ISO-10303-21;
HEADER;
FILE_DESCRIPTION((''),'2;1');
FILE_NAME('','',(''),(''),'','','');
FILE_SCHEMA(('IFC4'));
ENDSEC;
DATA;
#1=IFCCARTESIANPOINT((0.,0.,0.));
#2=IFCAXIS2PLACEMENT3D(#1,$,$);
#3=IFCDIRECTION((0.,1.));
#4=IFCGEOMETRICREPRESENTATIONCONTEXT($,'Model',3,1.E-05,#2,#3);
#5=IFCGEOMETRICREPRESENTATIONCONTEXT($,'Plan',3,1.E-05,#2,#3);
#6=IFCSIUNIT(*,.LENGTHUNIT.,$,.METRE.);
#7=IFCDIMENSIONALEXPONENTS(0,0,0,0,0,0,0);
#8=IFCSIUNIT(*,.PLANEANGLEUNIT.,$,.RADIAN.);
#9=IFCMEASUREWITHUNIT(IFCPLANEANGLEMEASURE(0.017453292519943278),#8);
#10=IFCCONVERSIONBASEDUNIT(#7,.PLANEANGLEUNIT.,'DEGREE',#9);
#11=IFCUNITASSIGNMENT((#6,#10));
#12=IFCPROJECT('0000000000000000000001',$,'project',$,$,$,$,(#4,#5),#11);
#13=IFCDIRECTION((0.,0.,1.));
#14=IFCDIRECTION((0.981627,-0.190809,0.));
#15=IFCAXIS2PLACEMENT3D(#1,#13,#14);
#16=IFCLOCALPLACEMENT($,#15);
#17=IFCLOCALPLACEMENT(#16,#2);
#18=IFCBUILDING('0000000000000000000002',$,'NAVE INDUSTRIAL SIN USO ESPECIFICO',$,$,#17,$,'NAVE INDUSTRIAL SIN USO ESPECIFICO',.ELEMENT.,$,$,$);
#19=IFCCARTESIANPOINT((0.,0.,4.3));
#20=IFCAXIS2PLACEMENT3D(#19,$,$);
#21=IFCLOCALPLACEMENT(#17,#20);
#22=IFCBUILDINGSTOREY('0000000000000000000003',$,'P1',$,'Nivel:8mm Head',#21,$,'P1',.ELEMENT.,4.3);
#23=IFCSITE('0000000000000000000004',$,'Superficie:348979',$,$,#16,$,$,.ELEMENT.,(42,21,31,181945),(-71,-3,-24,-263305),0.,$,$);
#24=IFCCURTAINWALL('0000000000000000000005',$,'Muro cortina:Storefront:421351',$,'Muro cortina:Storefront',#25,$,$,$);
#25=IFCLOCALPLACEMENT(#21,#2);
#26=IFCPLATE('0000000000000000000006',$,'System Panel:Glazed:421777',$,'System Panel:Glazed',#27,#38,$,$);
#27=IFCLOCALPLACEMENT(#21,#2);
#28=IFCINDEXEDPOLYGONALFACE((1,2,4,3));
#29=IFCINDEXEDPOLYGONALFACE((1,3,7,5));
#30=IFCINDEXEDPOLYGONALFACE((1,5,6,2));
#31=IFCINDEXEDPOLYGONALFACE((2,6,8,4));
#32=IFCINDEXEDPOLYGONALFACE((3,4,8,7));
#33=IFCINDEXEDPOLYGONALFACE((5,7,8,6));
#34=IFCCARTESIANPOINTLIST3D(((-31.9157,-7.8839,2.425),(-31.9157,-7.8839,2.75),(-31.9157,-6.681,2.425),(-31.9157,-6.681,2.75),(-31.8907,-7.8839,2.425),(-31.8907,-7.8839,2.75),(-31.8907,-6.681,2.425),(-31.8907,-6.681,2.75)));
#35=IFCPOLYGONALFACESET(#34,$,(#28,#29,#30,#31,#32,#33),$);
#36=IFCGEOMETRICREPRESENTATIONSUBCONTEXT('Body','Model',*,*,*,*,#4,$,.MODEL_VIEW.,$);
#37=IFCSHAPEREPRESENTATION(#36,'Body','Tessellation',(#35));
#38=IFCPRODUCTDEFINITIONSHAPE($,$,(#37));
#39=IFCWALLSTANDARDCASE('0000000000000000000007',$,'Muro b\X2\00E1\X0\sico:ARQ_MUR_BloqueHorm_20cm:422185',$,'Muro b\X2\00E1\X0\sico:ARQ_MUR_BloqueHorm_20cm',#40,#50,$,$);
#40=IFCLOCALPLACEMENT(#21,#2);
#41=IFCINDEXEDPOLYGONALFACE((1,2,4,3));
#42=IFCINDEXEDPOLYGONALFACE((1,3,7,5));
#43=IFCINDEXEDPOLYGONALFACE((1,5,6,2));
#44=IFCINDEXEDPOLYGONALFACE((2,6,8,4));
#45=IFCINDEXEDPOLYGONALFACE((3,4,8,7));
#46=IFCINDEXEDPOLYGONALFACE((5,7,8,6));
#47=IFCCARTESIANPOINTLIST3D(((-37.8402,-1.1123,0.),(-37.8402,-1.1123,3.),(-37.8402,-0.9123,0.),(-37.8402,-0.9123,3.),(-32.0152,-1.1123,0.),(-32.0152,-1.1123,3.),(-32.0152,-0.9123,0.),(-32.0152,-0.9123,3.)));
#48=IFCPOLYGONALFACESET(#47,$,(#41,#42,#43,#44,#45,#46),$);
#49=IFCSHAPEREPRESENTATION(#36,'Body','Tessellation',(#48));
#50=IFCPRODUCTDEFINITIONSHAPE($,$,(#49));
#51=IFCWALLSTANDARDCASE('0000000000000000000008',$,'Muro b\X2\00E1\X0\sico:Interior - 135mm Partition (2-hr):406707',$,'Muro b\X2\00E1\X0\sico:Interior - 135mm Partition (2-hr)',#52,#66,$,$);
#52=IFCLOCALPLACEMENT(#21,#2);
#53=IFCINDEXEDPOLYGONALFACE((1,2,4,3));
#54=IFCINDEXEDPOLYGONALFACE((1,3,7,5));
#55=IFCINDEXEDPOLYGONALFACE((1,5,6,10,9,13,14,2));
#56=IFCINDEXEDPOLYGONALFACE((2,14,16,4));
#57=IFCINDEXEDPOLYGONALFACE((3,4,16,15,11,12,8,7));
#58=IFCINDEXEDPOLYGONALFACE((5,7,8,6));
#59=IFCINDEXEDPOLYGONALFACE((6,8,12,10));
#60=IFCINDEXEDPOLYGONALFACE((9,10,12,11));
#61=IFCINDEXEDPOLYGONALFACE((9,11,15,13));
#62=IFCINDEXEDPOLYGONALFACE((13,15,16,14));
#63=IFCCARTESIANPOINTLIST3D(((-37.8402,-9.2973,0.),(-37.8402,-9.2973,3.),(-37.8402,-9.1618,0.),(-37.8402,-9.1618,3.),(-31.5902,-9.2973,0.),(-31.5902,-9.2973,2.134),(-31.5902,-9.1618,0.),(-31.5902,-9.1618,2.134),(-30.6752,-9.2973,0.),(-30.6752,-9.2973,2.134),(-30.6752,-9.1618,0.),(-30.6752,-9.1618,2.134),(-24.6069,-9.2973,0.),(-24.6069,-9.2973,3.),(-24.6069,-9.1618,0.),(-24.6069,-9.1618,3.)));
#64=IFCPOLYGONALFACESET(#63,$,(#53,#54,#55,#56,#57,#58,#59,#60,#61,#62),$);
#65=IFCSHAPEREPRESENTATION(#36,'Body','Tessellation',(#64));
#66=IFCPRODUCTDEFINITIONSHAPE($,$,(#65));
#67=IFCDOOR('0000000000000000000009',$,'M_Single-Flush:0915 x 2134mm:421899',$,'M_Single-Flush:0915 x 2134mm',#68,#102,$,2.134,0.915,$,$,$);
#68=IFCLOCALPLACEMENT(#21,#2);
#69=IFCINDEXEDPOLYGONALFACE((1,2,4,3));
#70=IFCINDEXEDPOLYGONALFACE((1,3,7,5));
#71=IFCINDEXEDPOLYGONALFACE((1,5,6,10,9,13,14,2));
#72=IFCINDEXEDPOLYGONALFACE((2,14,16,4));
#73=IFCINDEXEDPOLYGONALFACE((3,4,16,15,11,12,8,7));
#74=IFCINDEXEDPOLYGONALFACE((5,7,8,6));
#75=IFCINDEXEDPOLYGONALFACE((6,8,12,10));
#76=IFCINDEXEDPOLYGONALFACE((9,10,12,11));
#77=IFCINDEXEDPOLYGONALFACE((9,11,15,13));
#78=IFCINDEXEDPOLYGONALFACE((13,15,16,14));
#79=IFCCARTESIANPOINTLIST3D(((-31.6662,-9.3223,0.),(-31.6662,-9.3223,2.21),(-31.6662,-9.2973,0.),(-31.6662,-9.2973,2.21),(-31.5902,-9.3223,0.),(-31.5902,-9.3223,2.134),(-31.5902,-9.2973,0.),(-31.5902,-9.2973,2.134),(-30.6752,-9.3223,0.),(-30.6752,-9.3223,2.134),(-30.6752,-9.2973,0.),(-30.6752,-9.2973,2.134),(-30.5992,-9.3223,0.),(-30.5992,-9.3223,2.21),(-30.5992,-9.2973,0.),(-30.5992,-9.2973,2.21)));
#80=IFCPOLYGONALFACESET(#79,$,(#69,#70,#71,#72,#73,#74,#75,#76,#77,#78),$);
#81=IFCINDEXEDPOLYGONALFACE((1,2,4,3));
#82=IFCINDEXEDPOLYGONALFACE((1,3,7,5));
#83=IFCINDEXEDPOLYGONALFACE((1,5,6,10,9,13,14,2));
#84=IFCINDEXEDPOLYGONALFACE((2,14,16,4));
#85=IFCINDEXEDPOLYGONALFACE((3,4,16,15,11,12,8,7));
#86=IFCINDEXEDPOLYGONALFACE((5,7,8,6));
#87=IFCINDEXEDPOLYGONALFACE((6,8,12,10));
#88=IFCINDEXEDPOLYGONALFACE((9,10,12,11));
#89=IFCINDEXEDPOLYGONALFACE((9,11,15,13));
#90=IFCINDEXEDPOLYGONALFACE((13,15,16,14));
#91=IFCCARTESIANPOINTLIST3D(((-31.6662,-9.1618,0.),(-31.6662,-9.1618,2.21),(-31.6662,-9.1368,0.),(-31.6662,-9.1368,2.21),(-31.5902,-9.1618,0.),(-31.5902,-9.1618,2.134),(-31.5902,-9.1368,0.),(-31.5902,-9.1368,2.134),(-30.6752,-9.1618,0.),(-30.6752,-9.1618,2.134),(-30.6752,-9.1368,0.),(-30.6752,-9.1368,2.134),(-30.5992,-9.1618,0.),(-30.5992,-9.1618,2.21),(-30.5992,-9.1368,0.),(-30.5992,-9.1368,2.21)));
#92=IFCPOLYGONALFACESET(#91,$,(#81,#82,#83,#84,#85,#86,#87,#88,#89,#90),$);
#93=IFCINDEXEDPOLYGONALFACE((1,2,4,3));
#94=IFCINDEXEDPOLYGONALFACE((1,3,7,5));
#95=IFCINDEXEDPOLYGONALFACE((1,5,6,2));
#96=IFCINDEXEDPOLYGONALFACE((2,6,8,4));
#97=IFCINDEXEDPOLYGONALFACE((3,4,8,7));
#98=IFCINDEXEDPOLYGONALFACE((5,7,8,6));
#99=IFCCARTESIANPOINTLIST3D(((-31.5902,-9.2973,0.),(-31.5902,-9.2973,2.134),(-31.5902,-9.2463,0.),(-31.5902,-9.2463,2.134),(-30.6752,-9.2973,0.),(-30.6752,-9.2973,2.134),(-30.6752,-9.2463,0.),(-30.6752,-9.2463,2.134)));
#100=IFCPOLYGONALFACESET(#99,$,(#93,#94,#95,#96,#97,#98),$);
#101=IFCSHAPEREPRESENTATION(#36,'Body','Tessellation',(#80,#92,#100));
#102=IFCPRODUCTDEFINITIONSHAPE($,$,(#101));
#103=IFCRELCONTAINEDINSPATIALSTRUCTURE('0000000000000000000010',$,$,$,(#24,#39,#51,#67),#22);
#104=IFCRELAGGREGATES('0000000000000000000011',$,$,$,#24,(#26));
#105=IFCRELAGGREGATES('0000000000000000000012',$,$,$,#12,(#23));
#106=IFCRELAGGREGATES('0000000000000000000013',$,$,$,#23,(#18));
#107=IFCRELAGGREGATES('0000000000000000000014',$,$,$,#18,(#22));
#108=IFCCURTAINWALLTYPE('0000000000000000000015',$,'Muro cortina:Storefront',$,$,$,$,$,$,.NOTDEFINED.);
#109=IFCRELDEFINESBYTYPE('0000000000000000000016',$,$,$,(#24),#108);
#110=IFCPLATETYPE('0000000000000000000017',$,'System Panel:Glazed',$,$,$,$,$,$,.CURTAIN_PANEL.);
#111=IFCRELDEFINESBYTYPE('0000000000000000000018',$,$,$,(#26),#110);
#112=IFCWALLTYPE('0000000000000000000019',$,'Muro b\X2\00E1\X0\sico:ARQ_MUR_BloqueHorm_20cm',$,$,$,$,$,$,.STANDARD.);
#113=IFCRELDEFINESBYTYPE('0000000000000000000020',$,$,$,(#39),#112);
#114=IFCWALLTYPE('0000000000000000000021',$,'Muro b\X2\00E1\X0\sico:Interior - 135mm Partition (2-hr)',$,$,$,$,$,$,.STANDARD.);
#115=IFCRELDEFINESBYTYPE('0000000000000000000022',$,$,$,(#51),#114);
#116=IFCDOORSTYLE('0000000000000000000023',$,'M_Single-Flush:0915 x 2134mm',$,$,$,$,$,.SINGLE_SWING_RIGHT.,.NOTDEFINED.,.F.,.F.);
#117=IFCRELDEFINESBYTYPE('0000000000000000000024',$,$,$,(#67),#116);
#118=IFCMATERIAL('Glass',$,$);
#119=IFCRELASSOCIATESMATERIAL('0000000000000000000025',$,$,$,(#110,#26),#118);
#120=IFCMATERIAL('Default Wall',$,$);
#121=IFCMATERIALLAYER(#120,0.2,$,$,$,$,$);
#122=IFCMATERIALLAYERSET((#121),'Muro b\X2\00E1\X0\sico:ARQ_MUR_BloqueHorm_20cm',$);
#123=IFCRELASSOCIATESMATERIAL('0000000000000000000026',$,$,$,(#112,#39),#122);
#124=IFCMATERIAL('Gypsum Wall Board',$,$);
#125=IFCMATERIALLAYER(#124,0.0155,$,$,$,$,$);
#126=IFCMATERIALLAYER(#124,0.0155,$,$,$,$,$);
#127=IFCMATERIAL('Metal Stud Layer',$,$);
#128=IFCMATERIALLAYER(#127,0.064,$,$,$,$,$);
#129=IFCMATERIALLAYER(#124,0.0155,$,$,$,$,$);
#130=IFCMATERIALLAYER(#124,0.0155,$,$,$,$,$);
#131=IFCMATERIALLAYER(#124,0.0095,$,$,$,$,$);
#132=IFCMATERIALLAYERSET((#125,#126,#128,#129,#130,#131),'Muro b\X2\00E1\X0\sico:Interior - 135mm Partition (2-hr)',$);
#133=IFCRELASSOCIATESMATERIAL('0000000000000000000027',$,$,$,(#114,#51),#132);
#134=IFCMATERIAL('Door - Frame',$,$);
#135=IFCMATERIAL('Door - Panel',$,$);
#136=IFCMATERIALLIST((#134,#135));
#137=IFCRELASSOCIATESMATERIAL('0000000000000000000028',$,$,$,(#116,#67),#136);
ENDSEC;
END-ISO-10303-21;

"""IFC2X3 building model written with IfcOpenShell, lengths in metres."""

from ifc_helpers import new_model, entity, si_unit, converted_unit, direction, frame, frame_2d, origin, origin_2d_with_axis, place, context, subcontext, project, spatial, polyline, rectangle, outline, extrude, source, transform, mapped, material, material_list, layer, layer_set, layer_usage, type_object, type_shapes, element, fill, aggregate, save


model = new_model("IFC2X3")

# Units and contexts
model_context = context("Model", 3, precision=1e-05, world=origin(), true_north=direction((0.0, 1.0)))
plan_context = context("Plan", 3, precision=1e-05, world=origin(), true_north=direction((0.0, 1.0)))
body_context = subcontext(model_context, "Body", "Model", "MODEL_VIEW")
ifc_project = project(units=[si_unit("LENGTHUNIT", "METRE"), converted_unit("PLANEANGLEUNIT", "DEGREE", entity("IfcPlaneAngleMeasure", 0.017453292519943278), si_unit("PLANEANGLEUNIT", "RADIAN"), dimensions=[0, 0, 0, 0, 0, 0, 0])], contexts=[model_context, plan_context])

# Site, building, storey
site_placement = place(None, frame((0.0, 0.0, 0.0), z_axis=(0.0, 0.0, 1.0), x_axis=(0.981627, -0.190809, 0.0)))
site = spatial("IfcSite", under=ifc_project, at=site_placement, Name="Superficie:348979", CompositionType="ELEMENT", RefLatitude=(42, 21, 31, 181945), RefLongitude=(-71, -3, -24, -263305), RefElevation=0.0)
building_placement = place(site_placement, origin())
building = spatial("IfcBuilding", under=site, at=building_placement, Name="NAVE INDUSTRIAL SIN USO ESPECIFICO", LongName="NAVE INDUSTRIAL SIN USO ESPECIFICO", CompositionType="ELEMENT")
storey_placement = place(building_placement, frame((0.0, 0.0, 4.3)))
storey = spatial("IfcBuildingStorey", under=building, at=storey_placement, Name="P1", ObjectType="Nivel:8mm Head", LongName="P1", CompositionType="ELEMENT", Elevation=4.3)

# Curtain wall, plate
curtain_wall_type = type_object("IfcCurtainWallType", Name="Muro cortina:Storefront", PredefinedType="NOTDEFINED")
curtain_wall_placement = place(storey_placement, frame((0.0, 0.0, -4.3)))
curtain_wall = element("IfcCurtainWall", 1, at=curtain_wall_placement, inside=storey, type_object=curtain_wall_type, Name="Muro cortina:Storefront:421351", ObjectType="Muro cortina:Storefront")
ifc_material_1 = material(Name="Glass")
ifc_material_2 = material(Name="Gypsum Wall Board")
ifc_material_3 = material(Name="Door - Frame")
ifc_material_4 = material(Name="Door - Panel")
ifc_material_list = material_list([ifc_material_3, ifc_material_4])
plate_type_1 = type_object("IfcPlateType", Name="System Panel:Glazed", PredefinedType="CURTAIN_PANEL", material=ifc_material_1)
shared_shape_1 = source(origin(), body_context, "Body", "SweptSolid", [
    extrude(rectangle(XDim=0.025, YDim=1.2029, at=origin_2d_with_axis()), frame((0.6014, 0.0125, 0.0), z_axis=(0.0, 0.0, 1.0), x_axis=(0.0, 1.0, 0.0)), (0.0, 0.0, 1.0), 0.325),
])
type_shapes(plate_type_1, [shared_shape_1])
plate_1_placement = place(curtain_wall_placement, frame((-31.9157, -6.681, 6.725), z_axis=(0.0, 0.0, 1.0), x_axis=(0.0, -1.0, 0.0)))
plate_1 = element("IfcPlate", 2, at=plate_1_placement, type_object=plate_type_1, material=ifc_material_1, Name="System Panel:Glazed:421777", ObjectType="System Panel:Glazed", context=body_context, shape_type="MappedRepresentation", body=[
    mapped(shared_shape_1, transform((0.0, 0.0, 0.0), scale=1.0)),
])
aggregate(curtain_wall, [plate_1])

# Wall
ifc_material_5 = material(Name="Default Wall")
ifc_layer_1 = layer(ifc_material_5, 0.2)
ifc_layer_set_1 = layer_set([ifc_layer_1], Name="Muro básico:ARQ_MUR_BloqueHorm_20cm")
ifc_layer_usage_1 = layer_usage(ifc_layer_set_1, "AXIS2", "NEGATIVE", 0.1)
wall_type_1 = type_object("IfcWallType", Name="Muro básico:ARQ_MUR_BloqueHorm_20cm", PredefinedType="STANDARD", material=ifc_layer_set_1)
wall_1_placement = place(storey_placement, frame((-37.8402, -1.0123, 0.0)))
element("IfcWallStandardCase", 3, at=wall_1_placement, inside=storey, type_object=wall_type_1, material=ifc_layer_usage_1, Name="Muro básico:ARQ_MUR_BloqueHorm_20cm:422185", ObjectType="Muro básico:ARQ_MUR_BloqueHorm_20cm", context=body_context, shape_type="SweptSolid", body=[
    extrude(rectangle(XDim=5.825, YDim=0.2, at=frame_2d((2.9125, 0.0), x_axis=(-1.0, 0.0))), origin(), (0.0, 0.0, 1.0), 3.0),
])

# Wall, opening, door
ifc_layer_2 = layer(ifc_material_2, 0.0155)
ifc_layer_3 = layer(ifc_material_2, 0.0155)
ifc_material_6 = material(Name="Metal Stud Layer")
ifc_layer_4 = layer(ifc_material_6, 0.064)
ifc_layer_5 = layer(ifc_material_2, 0.0155)
ifc_layer_6 = layer(ifc_material_2, 0.0155)
ifc_layer_7 = layer(ifc_material_2, 0.0095)
ifc_layer_set_2 = layer_set([ifc_layer_2, ifc_layer_3, ifc_layer_4, ifc_layer_5, ifc_layer_6, ifc_layer_7], Name="Muro básico:Interior - 135mm Partition (2-hr)")
ifc_layer_usage_2 = layer_usage(ifc_layer_set_2, "AXIS2", "NEGATIVE", 0.0677)
wall_type_2 = type_object("IfcWallType", Name="Muro básico:Interior - 135mm Partition (2-hr)", PredefinedType="STANDARD", material=ifc_layer_set_2)
wall_2_placement = place(storey_placement, frame((-37.8402, -9.2296, 0.0)))
wall_2 = element("IfcWallStandardCase", 4, at=wall_2_placement, inside=storey, type_object=wall_type_2, material=ifc_layer_usage_2, Name="Muro básico:Interior - 135mm Partition (2-hr):406707", ObjectType="Muro básico:Interior - 135mm Partition (2-hr)", context=body_context, shape_type="SweptSolid", body=[
    extrude(rectangle(XDim=13.2333, YDim=0.1355, at=frame_2d((6.6167, 0.0), x_axis=(1.0, 0.0))), origin(), (0.0, 0.0, 1.0), 3.0),
])
opening_1_placement = place(wall_2_placement, frame((7.165, 0.0677, 0.0)))
opening_1 = element("IfcOpeningElement", 5, at=opening_1_placement, cuts=wall_2, ObjectType="Opening", context=body_context, shape_type="SweptSolid", body=[
    extrude(rectangle(XDim=0.915, YDim=2.134, at=frame_2d((1.067, 0.4575), x_axis=(0.0, 1.0))), frame((0.0, 0.0, 0.0), z_axis=(0.0, -1.0, 0.0), x_axis=(0.0, 0.0, 1.0)), (0.0, 0.0, 1.0), 0.1355),
])
door_style_1 = type_object("IfcDoorStyle", Name="M_Single-Flush:0915 x 2134mm", ConstructionType="NOTDEFINED", OperationType="SINGLE_SWING_RIGHT", ParameterTakesPrecedence=False, Sizeable=False, material=ifc_material_list)
shared_shape_2 = source(origin(), body_context, "Body", "SweptSolid", [
    extrude(outline(polyline([(-0.5335, -1.124), (0.5335, -1.124), (0.5335, 1.086), (0.4575, 1.086), (0.4575, -1.048), (-0.4575, -1.048), (-0.4575, 1.086), (-0.5335, 1.086), (-0.5335, -1.124)])), frame((0.4575, 0.1355, 1.086), z_axis=(0.0, 1.0, 0.0), x_axis=(1.0, 0.0, 0.0)), (0.0, 0.0, 1.0), 0.025),
    extrude(outline(polyline([(-1.124, -0.5335), (1.086, -0.5335), (1.086, -0.4575), (-1.048, -0.4575), (-1.048, 0.4575), (1.086, 0.4575), (1.086, 0.5335), (-1.124, 0.5335), (-1.124, -0.5335)])), frame((0.4575, -0.025, 1.086), z_axis=(0.0, 1.0, 0.0), x_axis=(0.0, 0.0, -1.0)), (0.0, 0.0, 1.0), 0.025),
    extrude(rectangle(XDim=0.051, YDim=0.915, at=frame_2d((0.0, 0.0), x_axis=(1.0, 0.0))), frame((0.4575, 0.11, 0.0), z_axis=(0.0, 0.0, 1.0), x_axis=(0.0, 1.0, 0.0)), (0.0, 0.0, 1.0), 2.134),
])
type_shapes(door_style_1, [shared_shape_2])
door_1_placement = place(opening_1_placement, frame((0.0, 0.0, 0.0), z_axis=(0.0, 0.0, 1.0), x_axis=(-1.0, 0.0, 0.0)))
door_1 = element("IfcDoor", 6, at=door_1_placement, inside=storey, type_object=door_style_1, material=ifc_material_list, Name="M_Single-Flush:0915 x 2134mm:421899", ObjectType="M_Single-Flush:0915 x 2134mm", OverallHeight=2.134, OverallWidth=0.915, context=body_context, shape_type="MappedRepresentation", body=[
    mapped(shared_shape_2, transform((0.0, 0.0, 0.0), scale=1.0)),
])
fill(opening_1, door_1)

save(model, "model.ifc")
